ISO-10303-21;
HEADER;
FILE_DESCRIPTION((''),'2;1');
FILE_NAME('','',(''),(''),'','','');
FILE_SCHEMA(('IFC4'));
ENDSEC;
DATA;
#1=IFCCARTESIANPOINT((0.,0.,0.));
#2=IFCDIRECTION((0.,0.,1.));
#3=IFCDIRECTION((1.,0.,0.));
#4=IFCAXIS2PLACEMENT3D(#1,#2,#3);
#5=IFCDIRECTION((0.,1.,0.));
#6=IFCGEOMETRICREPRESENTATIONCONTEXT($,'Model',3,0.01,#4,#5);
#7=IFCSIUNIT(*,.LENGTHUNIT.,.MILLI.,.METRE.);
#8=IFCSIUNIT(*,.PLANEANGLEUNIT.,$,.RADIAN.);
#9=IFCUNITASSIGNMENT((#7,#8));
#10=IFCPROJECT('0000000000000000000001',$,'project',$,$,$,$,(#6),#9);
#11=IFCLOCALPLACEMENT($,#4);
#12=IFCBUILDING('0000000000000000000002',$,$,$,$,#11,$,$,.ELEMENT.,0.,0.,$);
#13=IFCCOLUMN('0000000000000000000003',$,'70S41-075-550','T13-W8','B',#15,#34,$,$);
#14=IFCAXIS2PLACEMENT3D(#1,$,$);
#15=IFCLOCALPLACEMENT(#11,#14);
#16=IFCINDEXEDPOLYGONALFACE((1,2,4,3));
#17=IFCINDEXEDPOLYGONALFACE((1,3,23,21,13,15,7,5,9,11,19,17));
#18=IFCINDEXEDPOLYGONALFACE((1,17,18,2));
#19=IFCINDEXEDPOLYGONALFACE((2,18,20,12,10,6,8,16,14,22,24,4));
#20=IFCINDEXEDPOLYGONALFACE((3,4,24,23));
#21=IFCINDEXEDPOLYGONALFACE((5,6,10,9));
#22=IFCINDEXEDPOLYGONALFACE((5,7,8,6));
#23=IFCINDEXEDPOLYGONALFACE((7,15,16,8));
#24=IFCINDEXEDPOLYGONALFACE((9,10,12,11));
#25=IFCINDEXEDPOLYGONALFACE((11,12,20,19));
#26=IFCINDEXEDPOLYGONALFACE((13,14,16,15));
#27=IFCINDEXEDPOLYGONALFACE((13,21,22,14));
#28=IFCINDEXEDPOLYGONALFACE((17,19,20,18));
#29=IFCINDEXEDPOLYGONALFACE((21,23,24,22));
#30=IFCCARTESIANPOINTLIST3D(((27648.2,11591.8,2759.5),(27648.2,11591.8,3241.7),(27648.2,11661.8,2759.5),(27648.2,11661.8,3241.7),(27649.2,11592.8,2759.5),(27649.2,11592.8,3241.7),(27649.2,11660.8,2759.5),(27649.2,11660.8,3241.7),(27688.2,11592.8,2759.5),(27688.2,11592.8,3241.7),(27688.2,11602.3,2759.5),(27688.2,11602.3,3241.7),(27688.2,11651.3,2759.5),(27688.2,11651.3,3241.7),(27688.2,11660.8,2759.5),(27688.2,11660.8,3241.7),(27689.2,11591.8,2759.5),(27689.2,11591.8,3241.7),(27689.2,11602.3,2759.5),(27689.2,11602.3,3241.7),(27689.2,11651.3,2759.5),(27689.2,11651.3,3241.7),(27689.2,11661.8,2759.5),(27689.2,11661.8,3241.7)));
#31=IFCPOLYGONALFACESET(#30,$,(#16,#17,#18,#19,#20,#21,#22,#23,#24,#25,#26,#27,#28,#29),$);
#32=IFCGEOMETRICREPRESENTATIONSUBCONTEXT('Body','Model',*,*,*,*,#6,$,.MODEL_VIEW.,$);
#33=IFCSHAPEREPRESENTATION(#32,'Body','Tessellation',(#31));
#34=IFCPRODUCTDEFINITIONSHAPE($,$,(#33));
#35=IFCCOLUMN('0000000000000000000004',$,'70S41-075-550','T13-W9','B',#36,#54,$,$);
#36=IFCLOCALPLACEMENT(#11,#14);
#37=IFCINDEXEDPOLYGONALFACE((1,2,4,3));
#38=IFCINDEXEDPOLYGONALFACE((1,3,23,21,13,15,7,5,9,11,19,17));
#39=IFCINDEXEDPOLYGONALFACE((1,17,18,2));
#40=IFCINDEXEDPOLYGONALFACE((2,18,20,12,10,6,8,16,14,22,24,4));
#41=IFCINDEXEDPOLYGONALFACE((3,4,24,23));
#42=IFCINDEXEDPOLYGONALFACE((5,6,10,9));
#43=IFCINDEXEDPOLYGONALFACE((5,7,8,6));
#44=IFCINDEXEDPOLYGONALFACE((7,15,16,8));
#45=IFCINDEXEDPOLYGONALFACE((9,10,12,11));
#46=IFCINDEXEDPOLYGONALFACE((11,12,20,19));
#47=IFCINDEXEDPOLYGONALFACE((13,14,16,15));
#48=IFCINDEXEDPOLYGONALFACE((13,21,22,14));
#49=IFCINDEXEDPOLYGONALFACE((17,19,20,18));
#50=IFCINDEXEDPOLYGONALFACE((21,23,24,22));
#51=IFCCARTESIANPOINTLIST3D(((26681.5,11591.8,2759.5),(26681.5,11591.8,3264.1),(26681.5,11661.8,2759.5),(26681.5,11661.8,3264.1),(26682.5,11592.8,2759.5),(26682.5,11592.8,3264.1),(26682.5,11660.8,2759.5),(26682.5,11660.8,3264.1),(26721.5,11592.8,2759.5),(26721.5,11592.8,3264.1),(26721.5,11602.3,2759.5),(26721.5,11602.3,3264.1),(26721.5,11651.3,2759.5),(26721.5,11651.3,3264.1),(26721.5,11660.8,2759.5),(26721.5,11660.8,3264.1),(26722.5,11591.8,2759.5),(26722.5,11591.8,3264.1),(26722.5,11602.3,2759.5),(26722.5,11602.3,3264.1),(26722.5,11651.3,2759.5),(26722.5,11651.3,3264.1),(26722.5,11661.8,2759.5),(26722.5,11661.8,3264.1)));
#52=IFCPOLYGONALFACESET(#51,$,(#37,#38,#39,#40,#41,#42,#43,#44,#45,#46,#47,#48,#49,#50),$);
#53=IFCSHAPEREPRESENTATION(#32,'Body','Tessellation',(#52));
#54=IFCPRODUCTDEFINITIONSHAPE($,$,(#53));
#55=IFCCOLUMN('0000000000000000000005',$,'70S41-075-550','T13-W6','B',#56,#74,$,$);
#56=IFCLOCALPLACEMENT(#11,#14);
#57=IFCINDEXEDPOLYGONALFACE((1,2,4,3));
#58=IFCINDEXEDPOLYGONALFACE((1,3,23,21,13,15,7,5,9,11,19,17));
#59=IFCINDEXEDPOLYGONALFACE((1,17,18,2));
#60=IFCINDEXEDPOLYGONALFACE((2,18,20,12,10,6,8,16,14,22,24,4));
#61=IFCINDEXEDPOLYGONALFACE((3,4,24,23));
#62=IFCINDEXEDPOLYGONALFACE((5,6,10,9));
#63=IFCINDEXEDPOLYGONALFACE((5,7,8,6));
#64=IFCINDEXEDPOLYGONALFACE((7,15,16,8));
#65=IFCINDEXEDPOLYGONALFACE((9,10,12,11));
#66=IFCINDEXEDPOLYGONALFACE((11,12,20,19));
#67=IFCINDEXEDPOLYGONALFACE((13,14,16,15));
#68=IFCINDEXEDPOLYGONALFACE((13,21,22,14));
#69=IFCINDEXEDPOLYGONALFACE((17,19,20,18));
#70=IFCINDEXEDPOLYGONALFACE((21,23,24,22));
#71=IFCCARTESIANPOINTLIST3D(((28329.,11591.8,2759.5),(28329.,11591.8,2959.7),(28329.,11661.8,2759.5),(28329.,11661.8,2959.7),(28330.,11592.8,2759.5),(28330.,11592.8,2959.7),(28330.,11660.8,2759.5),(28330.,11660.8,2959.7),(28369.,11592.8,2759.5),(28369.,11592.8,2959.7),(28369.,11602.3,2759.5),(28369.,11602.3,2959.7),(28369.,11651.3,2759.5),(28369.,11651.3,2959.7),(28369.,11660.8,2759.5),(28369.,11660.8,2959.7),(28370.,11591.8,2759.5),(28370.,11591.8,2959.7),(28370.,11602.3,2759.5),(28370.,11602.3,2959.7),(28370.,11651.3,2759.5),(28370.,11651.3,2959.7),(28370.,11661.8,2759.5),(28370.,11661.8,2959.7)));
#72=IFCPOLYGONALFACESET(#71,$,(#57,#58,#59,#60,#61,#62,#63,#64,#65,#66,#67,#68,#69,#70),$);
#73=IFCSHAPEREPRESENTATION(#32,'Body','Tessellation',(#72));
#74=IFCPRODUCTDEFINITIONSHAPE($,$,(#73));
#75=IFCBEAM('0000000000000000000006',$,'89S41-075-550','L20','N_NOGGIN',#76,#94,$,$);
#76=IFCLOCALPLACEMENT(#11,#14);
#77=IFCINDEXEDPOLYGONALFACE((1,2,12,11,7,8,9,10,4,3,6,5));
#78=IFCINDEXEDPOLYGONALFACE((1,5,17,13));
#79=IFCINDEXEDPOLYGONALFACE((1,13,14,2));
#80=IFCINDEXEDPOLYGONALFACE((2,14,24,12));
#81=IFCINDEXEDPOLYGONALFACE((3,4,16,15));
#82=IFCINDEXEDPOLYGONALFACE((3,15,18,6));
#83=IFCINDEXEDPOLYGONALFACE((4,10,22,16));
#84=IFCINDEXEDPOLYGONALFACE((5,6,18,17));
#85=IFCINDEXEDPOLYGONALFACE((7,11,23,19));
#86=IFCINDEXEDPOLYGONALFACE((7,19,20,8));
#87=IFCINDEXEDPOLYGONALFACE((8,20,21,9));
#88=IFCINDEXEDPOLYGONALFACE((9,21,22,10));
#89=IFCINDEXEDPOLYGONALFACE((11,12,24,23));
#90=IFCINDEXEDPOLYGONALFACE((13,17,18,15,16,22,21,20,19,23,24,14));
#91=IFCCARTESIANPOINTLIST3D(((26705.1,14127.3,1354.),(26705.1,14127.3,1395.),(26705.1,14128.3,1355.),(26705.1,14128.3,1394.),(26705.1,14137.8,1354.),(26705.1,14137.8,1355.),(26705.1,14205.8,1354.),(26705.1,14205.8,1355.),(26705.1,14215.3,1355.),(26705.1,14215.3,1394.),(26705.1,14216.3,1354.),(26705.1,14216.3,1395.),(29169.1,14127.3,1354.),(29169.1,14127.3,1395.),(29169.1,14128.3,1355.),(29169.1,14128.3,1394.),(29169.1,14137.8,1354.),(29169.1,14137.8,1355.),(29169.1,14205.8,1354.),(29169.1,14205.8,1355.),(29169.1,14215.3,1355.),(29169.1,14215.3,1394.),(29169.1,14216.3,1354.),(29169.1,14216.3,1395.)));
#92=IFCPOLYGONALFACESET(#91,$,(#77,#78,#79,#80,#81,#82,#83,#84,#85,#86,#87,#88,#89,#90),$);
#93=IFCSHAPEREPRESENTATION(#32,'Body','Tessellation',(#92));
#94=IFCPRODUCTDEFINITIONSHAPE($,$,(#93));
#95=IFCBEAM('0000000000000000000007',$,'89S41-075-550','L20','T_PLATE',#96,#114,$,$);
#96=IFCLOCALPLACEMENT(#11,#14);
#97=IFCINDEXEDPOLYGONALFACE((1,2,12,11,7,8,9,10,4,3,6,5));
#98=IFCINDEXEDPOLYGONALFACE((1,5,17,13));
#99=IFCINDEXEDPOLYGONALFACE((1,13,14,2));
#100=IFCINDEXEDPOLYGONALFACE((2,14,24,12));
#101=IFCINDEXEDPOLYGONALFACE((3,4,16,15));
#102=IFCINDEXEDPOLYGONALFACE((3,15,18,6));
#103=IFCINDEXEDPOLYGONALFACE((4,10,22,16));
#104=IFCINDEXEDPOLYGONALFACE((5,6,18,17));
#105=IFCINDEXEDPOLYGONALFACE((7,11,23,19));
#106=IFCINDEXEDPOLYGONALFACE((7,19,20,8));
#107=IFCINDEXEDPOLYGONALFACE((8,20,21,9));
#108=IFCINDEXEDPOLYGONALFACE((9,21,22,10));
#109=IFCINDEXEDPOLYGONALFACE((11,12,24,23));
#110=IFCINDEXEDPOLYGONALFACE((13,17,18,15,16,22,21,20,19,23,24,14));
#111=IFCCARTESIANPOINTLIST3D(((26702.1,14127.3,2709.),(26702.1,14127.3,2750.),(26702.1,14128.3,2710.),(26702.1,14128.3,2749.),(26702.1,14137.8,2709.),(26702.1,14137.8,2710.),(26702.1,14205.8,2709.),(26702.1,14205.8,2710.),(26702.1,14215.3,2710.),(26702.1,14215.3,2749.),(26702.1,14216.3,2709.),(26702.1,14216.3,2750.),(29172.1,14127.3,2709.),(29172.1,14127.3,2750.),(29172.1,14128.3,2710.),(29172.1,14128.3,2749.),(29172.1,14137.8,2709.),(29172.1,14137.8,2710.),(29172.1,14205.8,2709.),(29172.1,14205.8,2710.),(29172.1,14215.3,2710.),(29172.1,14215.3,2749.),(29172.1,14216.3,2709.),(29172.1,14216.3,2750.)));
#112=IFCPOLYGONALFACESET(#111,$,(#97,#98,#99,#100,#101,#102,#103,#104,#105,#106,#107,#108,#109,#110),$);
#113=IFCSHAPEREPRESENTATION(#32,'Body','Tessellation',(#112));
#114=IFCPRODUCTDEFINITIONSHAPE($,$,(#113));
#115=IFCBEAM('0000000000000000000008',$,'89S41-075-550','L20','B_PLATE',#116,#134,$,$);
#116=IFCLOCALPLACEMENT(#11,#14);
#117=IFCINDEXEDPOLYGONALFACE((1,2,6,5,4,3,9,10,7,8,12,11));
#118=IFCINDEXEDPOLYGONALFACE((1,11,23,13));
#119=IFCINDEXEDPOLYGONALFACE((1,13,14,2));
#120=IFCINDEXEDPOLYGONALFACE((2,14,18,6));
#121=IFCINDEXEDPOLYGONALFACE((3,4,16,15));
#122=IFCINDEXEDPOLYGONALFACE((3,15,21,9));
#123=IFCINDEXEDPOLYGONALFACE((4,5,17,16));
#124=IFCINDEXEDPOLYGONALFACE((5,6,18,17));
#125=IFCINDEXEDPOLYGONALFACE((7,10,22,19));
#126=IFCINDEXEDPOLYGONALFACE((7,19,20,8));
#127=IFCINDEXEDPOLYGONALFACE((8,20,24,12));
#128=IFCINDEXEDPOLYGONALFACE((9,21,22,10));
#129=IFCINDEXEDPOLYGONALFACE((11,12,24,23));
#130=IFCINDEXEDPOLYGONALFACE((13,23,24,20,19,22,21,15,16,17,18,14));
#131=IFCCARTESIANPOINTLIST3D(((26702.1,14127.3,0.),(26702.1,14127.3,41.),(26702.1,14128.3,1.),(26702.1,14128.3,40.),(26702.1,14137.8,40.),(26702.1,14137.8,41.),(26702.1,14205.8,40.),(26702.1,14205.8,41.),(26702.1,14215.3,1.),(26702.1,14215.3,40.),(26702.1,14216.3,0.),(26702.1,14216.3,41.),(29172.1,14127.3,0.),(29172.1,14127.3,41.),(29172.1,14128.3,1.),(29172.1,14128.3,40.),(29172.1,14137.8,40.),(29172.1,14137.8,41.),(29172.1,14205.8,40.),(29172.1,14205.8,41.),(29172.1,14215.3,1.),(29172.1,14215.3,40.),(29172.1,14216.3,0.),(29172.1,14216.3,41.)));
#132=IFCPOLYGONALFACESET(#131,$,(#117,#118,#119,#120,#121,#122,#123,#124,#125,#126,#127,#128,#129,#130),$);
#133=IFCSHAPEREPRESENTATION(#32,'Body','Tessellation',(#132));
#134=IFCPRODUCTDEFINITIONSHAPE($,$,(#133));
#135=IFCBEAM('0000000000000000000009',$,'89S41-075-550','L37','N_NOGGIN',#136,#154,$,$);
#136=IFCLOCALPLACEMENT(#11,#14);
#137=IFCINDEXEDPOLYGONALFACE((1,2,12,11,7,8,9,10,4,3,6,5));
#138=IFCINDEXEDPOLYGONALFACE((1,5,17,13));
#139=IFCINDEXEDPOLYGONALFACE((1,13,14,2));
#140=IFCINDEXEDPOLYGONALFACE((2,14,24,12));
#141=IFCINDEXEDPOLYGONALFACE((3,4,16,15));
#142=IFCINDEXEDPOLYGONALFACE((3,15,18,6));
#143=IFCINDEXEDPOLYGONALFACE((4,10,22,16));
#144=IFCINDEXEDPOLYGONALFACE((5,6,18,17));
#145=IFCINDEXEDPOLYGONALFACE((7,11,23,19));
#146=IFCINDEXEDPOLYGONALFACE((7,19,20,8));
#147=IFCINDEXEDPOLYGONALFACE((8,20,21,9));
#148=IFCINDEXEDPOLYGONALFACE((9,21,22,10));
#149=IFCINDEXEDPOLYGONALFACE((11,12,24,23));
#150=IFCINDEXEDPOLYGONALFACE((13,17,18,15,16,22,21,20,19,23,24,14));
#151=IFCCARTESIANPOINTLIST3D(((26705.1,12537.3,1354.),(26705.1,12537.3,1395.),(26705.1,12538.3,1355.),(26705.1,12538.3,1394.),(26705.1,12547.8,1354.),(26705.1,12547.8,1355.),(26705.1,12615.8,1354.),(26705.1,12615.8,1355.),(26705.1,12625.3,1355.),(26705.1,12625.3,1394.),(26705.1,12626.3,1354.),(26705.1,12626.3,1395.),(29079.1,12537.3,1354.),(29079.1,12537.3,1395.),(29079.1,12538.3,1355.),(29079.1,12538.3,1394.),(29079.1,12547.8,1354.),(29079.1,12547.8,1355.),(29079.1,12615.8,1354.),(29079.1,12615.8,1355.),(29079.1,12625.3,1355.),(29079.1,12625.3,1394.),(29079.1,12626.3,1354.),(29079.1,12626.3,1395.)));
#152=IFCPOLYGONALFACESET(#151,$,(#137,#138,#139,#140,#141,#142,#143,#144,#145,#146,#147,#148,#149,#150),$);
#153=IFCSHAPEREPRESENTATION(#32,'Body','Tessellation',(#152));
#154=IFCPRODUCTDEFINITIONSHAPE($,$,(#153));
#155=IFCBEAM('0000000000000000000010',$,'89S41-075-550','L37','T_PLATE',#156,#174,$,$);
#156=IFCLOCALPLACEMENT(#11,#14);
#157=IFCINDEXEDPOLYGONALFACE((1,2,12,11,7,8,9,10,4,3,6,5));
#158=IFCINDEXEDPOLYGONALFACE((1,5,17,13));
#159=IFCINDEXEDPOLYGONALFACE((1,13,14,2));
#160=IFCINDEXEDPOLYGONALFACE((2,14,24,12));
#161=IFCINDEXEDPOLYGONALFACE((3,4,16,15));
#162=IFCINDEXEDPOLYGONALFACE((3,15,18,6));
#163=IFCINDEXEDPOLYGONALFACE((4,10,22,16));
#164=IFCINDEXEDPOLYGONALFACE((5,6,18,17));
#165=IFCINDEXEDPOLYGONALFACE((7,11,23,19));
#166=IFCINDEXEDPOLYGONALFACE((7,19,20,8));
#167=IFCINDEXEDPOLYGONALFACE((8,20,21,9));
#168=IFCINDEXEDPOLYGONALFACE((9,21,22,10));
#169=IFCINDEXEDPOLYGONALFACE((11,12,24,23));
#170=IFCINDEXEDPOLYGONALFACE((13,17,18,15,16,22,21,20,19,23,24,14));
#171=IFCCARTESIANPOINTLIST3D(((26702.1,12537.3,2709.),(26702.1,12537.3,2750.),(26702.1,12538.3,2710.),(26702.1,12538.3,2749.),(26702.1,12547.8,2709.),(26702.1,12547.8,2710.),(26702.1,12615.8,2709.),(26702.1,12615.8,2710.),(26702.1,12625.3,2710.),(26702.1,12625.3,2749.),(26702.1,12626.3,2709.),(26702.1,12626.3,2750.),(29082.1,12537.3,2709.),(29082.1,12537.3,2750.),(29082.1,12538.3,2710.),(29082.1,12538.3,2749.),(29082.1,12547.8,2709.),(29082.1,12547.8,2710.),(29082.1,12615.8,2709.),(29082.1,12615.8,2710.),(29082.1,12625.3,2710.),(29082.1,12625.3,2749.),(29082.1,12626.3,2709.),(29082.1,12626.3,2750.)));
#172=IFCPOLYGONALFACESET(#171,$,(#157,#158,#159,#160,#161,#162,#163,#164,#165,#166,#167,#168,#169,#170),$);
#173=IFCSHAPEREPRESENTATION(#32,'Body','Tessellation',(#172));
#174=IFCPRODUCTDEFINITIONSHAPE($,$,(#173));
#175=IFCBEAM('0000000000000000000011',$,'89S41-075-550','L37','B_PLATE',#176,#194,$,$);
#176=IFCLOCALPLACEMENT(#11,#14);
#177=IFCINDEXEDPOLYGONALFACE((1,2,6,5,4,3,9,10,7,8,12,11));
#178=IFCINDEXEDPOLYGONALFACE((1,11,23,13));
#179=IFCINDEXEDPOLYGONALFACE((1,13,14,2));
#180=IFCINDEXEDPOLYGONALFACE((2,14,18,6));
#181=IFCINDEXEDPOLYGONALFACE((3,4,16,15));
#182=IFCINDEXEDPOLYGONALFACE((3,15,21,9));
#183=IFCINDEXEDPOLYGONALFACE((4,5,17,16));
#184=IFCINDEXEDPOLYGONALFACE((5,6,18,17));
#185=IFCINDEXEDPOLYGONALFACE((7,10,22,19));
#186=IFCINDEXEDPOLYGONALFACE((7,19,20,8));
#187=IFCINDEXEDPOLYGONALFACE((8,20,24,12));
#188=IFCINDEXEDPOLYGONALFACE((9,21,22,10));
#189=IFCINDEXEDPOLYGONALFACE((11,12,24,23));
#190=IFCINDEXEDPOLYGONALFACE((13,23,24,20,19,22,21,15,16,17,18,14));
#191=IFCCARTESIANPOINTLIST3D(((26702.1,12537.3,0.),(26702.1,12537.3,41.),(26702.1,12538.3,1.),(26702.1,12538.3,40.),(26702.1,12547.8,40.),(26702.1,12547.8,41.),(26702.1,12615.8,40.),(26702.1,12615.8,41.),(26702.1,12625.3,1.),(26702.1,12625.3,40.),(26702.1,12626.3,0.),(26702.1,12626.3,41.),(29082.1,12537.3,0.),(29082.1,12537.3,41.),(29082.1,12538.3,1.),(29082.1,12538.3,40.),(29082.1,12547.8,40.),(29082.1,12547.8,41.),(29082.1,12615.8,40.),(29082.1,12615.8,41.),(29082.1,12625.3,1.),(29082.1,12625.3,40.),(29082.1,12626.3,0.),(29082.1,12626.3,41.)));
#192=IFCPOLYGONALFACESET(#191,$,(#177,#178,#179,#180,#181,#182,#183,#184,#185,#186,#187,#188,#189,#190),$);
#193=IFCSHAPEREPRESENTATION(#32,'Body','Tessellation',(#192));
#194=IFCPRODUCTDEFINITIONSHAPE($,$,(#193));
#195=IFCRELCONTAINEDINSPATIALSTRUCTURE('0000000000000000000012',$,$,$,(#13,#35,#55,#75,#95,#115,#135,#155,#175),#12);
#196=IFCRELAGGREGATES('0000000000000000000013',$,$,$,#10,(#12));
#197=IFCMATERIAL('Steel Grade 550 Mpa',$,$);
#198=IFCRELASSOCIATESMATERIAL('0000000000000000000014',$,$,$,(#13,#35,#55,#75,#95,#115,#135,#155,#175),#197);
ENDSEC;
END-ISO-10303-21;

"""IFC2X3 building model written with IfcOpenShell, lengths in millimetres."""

from ifc_helpers import new_model, si_unit, direction, frame, origin, origin_with_axes, origin_2d_with_axis, place, context, subcontext, project, spatial, c_section, extrude, source, transform, mapped, material, element, save


model = new_model("IFC2X3")

# Units and contexts
model_context = context("Model", 3, precision=0.01, world=origin_with_axes(), true_north=direction((0.0, 1.0, 0.0)))
body_context = subcontext(model_context, "Body", "Model", "MODEL_VIEW")
ifc_project = project(units=[si_unit("LENGTHUNIT", "METRE", prefix="MILLI"), si_unit("PLANEANGLEUNIT", "RADIAN")], contexts=[model_context])

# Building
building_placement = place(None, origin_with_axes())
building = spatial("IfcBuilding", under=ifc_project, at=building_placement, CompositionType="ELEMENT", ElevationOfRefHeight=0.0, ElevationOfTerrain=0.0)

# Columns
ifc_material = material(Name="Steel Grade 550 Mpa")
shared_shape_1 = source(origin(), body_context, "Body", "SweptSolid", [
    extrude(c_section(Depth=70.0, Width=41.0, WallThickness=1.0, Girth=10.5, at=origin_2d_with_axis()), origin_with_axes(), (0.0, 0.0, 1.0), 482.2),
])
column_1_placement = place(None, frame((27668.7, 11626.8, 2759.5), z_axis=(0.0, 0.0, 1.0), x_axis=(1.0, 0.0, 0.0)))
element("IfcColumn", 1, at=column_1_placement, inside=building, material=ifc_material, Name="70S41-075-550", Description="T13-W8", ObjectType="B", context=body_context, shape_type="MappedRepresentation", body=[
    mapped(shared_shape_1, transform((0.0, 0.0, 0.0), scale=1.0)),
])
shared_shape_2 = source(origin(), body_context, "Body", "SweptSolid", [
    extrude(c_section(Depth=70.0, Width=41.0, WallThickness=1.0, Girth=10.5, at=origin_2d_with_axis()), origin_with_axes(), (0.0, 0.0, 1.0), 504.6),
])
column_2_placement = place(None, frame((26702.0, 11626.8, 2759.5), z_axis=(0.0, 0.0, 1.0), x_axis=(1.0, 0.0, 0.0)))
element("IfcColumn", 2, at=column_2_placement, inside=building, material=ifc_material, Name="70S41-075-550", Description="T13-W9", ObjectType="B", context=body_context, shape_type="MappedRepresentation", body=[
    mapped(shared_shape_2, transform((0.0, 0.0, 0.0), scale=1.0)),
])
shared_shape_3 = source(origin(), body_context, "Body", "SweptSolid", [
    extrude(c_section(Depth=70.0, Width=41.0, WallThickness=1.0, Girth=10.5, at=origin_2d_with_axis()), origin_with_axes(), (0.0, 0.0, 1.0), 200.2),
])
column_3_placement = place(None, frame((28349.5, 11626.8, 2759.5), z_axis=(0.0, 0.0, 1.0), x_axis=(1.0, 0.0, 0.0)))
element("IfcColumn", 3, at=column_3_placement, inside=building, material=ifc_material, Name="70S41-075-550", Description="T13-W6", ObjectType="B", context=body_context, shape_type="MappedRepresentation", body=[
    mapped(shared_shape_3, transform((0.0, 0.0, 0.0), scale=1.0)),
])

# Beams
shared_shape_4 = source(origin(), body_context, "Body", "SweptSolid", [
    extrude(c_section(Depth=89.0, Width=41.0, WallThickness=1.0, Girth=10.5, at=origin_2d_with_axis()), origin_with_axes(), (0.0, 0.0, 1.0), 2464.0),
])
beam_1_placement = place(None, frame((26705.1, 14171.8, 1374.5), z_axis=(1.0, 0.0, 0.0), x_axis=(0.0, 0.0, -1.0)))
element("IfcBeam", 4, at=beam_1_placement, inside=building, material=ifc_material, Name="89S41-075-550", Description="L20", ObjectType="N_NOGGIN", context=body_context, shape_type="MappedRepresentation", body=[
    mapped(shared_shape_4, transform((0.0, 0.0, 0.0), scale=1.0)),
])
shared_shape_5 = source(origin(), body_context, "Body", "SweptSolid", [
    extrude(c_section(Depth=89.0, Width=41.0, WallThickness=1.0, Girth=10.5, at=origin_2d_with_axis()), origin_with_axes(), (0.0, 0.0, 1.0), 2470.0),
])
beam_2_placement = place(None, frame((26702.1, 14171.8, 2729.5), z_axis=(1.0, 0.0, 0.0), x_axis=(0.0, 0.0, -1.0)))
element("IfcBeam", 5, at=beam_2_placement, inside=building, material=ifc_material, Name="89S41-075-550", Description="L20", ObjectType="T_PLATE", context=body_context, shape_type="MappedRepresentation", body=[
    mapped(shared_shape_5, transform((0.0, 0.0, 0.0), scale=1.0)),
])
shared_shape_6 = source(origin(), body_context, "Body", "SweptSolid", [
    extrude(c_section(Depth=89.0, Width=41.0, WallThickness=1.0, Girth=10.5, at=origin_2d_with_axis()), origin_with_axes(), (0.0, 0.0, 1.0), 2470.0),
])
beam_3_placement = place(None, frame((26702.1, 14171.8, 20.5), z_axis=(1.0, 0.0, 0.0), x_axis=(0.0, 0.0, 1.0)))
element("IfcBeam", 6, at=beam_3_placement, inside=building, material=ifc_material, Name="89S41-075-550", Description="L20", ObjectType="B_PLATE", context=body_context, shape_type="MappedRepresentation", body=[
    mapped(shared_shape_6, transform((0.0, 0.0, 0.0), scale=1.0)),
])
shared_shape_7 = source(origin(), body_context, "Body", "SweptSolid", [
    extrude(c_section(Depth=89.0, Width=41.0, WallThickness=1.0, Girth=10.5, at=origin_2d_with_axis()), origin_with_axes(), (0.0, 0.0, 1.0), 2374.0),
])
beam_4_placement = place(None, frame((26705.1, 12581.8, 1374.5), z_axis=(1.0, 0.0, 0.0), x_axis=(0.0, 0.0, -1.0)))
element("IfcBeam", 7, at=beam_4_placement, inside=building, material=ifc_material, Name="89S41-075-550", Description="L37", ObjectType="N_NOGGIN", context=body_context, shape_type="MappedRepresentation", body=[
    mapped(shared_shape_7, transform((0.0, 0.0, 0.0), scale=1.0)),
])
shared_shape_8 = source(origin(), body_context, "Body", "SweptSolid", [
    extrude(c_section(Depth=89.0, Width=41.0, WallThickness=1.0, Girth=10.5, at=origin_2d_with_axis()), origin_with_axes(), (0.0, 0.0, 1.0), 2380.0),
])
beam_5_placement = place(None, frame((26702.1, 12581.8, 2729.5), z_axis=(1.0, 0.0, 0.0), x_axis=(0.0, 0.0, -1.0)))
element("IfcBeam", 8, at=beam_5_placement, inside=building, material=ifc_material, Name="89S41-075-550", Description="L37", ObjectType="T_PLATE", context=body_context, shape_type="MappedRepresentation", body=[
    mapped(shared_shape_8, transform((0.0, 0.0, 0.0), scale=1.0)),
])
shared_shape_9 = source(origin(), body_context, "Body", "SweptSolid", [
    extrude(c_section(Depth=89.0, Width=41.0, WallThickness=1.0, Girth=10.5, at=origin_2d_with_axis()), origin_with_axes(), (0.0, 0.0, 1.0), 2380.0),
])
beam_6_placement = place(None, frame((26702.1, 12581.8, 20.5), z_axis=(1.0, 0.0, 0.0), x_axis=(0.0, 0.0, 1.0)))
element("IfcBeam", 9, at=beam_6_placement, inside=building, material=ifc_material, Name="89S41-075-550", Description="L37", ObjectType="B_PLATE", context=body_context, shape_type="MappedRepresentation", body=[
    mapped(shared_shape_9, transform((0.0, 0.0, 0.0), scale=1.0)),
])

save(model, "model.ifc")
